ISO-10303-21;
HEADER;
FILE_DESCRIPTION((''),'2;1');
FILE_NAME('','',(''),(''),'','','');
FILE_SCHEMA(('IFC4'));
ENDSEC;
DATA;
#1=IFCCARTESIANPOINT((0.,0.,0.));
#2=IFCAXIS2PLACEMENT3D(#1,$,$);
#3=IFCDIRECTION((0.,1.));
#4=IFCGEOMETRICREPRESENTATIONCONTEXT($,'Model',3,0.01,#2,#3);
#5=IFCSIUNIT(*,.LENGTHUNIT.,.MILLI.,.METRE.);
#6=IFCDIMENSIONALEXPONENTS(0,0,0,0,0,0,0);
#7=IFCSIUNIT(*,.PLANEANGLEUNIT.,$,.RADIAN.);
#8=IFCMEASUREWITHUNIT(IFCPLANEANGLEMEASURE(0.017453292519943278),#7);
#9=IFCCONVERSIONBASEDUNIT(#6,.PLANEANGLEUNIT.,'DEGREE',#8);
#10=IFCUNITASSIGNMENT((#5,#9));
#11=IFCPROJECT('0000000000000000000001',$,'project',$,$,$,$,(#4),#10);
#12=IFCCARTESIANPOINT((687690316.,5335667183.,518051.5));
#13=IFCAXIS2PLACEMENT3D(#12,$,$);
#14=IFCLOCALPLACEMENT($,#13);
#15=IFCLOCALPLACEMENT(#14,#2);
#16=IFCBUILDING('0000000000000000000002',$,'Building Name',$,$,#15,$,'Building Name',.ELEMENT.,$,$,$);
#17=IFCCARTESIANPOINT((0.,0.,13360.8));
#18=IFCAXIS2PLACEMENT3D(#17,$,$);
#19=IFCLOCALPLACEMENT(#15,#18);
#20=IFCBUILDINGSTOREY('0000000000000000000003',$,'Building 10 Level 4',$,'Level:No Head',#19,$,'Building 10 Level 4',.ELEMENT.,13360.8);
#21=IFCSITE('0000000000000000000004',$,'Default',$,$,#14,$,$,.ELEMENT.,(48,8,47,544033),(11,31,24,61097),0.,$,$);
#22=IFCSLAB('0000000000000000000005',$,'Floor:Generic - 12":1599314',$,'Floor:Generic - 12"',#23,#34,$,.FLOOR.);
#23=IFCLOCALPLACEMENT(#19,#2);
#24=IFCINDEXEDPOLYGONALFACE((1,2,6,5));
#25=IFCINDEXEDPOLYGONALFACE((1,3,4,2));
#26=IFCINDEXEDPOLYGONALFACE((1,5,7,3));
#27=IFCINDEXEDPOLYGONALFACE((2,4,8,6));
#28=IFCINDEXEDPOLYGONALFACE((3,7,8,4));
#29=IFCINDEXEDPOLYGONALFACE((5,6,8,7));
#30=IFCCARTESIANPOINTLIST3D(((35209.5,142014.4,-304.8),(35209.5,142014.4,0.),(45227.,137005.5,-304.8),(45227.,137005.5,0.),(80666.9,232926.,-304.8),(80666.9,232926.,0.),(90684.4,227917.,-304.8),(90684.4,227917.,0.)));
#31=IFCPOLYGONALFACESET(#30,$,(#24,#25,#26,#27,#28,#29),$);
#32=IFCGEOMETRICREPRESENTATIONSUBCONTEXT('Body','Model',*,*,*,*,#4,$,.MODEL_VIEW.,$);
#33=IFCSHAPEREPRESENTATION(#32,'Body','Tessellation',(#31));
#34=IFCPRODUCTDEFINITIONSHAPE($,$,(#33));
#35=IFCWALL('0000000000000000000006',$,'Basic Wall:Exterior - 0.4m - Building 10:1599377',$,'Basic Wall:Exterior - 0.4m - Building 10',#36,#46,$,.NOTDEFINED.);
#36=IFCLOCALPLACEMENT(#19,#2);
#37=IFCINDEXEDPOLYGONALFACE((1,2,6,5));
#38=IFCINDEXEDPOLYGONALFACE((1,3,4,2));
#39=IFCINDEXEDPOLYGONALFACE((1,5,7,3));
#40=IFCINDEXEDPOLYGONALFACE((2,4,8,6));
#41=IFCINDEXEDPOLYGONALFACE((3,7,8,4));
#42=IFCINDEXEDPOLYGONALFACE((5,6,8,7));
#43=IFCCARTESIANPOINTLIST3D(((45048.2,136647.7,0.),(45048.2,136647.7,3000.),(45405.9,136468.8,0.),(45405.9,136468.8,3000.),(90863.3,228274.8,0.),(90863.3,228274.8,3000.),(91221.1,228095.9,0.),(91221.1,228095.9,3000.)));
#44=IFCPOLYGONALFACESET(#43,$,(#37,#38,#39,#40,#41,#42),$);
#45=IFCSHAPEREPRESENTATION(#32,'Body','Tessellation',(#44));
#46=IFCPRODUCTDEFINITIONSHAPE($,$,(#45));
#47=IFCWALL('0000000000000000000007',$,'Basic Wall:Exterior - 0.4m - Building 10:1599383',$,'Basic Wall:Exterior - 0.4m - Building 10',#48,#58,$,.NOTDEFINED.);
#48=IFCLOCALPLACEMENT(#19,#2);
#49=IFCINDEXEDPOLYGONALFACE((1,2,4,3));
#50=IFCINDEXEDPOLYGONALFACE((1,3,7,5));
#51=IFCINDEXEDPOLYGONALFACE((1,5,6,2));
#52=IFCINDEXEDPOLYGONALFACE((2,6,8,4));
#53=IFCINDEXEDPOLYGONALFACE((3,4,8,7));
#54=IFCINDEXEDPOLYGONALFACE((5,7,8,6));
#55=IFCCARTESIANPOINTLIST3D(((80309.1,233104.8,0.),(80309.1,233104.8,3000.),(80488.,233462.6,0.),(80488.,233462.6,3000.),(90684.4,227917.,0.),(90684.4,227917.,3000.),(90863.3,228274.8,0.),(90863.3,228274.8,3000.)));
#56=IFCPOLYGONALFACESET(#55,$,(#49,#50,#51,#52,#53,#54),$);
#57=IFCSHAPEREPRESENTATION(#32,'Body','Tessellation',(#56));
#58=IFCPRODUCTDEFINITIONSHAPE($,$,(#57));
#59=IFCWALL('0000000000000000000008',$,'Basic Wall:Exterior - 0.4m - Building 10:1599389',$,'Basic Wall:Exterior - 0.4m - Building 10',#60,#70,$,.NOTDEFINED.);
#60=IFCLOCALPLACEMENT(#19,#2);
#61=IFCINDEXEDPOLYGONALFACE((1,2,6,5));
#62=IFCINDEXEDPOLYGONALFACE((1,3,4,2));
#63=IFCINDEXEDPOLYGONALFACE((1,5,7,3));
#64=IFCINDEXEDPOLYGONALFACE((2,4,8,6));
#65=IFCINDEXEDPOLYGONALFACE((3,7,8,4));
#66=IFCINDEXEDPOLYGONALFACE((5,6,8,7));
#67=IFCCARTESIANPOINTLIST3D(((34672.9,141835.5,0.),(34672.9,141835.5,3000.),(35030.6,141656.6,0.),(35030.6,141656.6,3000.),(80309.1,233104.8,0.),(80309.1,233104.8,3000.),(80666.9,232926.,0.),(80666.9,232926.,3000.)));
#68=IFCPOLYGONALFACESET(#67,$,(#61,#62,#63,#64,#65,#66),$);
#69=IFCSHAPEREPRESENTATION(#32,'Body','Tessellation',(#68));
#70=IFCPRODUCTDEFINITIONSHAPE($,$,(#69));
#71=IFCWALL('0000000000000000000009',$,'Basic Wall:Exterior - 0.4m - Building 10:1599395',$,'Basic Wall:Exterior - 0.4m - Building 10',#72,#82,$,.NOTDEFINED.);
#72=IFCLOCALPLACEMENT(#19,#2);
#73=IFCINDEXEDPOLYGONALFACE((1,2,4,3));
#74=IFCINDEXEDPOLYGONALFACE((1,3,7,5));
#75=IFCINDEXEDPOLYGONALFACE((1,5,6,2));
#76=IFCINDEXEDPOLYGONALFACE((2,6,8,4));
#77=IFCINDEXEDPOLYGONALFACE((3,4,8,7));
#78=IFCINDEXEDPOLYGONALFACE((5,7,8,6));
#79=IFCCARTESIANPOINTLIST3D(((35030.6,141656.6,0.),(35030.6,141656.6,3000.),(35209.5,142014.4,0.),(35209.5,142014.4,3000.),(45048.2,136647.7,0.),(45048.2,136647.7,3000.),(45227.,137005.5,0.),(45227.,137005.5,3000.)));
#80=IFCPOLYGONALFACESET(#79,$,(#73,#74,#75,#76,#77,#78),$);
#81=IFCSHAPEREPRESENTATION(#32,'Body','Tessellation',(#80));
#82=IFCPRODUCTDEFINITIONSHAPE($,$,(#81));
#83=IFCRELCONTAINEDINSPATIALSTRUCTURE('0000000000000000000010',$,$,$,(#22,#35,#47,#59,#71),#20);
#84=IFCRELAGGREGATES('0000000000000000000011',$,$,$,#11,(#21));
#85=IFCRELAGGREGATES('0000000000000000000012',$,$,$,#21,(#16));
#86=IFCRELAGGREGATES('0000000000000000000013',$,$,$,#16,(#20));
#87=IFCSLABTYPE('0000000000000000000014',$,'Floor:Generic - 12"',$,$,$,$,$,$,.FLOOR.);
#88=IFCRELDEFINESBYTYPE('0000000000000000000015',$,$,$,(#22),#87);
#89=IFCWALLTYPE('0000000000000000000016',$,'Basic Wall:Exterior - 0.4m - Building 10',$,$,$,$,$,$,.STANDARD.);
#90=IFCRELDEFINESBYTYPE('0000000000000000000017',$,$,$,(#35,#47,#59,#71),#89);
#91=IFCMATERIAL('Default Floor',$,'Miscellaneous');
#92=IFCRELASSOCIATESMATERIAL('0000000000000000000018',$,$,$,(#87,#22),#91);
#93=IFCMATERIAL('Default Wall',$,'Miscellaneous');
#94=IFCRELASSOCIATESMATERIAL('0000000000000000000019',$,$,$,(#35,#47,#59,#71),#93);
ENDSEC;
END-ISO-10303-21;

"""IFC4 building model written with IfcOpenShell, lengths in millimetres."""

from ifc_helpers import new_model, entity, si_unit, converted_unit, direction, frame, origin, place, context, subcontext, project, spatial, indexed_curve, outline, extrude, material, type_object, element, save


model = new_model("IFC4")

# Units and contexts
model_context = context("Model", 3, precision=0.01, world=origin(), true_north=direction((0.0, 1.0)))
body_context = subcontext(model_context, "Body", "Model", "MODEL_VIEW")
ifc_project = project(units=[si_unit("LENGTHUNIT", "METRE", prefix="MILLI"), converted_unit("PLANEANGLEUNIT", "DEGREE", entity("IfcPlaneAngleMeasure", 0.017453292519943278), si_unit("PLANEANGLEUNIT", "RADIAN"), dimensions=[0, 0, 0, 0, 0, 0, 0])], contexts=[model_context])

# Site, building, storey
site_placement = place(None, frame((687690316.0, 5335667183.0, 518051.5)))
site = spatial("IfcSite", under=ifc_project, at=site_placement, Name="Default", CompositionType="ELEMENT", RefLatitude=(48, 8, 47, 544033), RefLongitude=(11, 31, 24, 61097), RefElevation=0.0)
building_placement = place(site_placement, origin())
building = spatial("IfcBuilding", under=site, at=building_placement, Name="Building Name", LongName="Building Name", CompositionType="ELEMENT")
storey_placement = place(building_placement, frame((0.0, 0.0, 13360.8)))
storey = spatial("IfcBuildingStorey", under=building, at=storey_placement, Name="Building 10 Level 4", ObjectType="Level:No Head", LongName="Building 10 Level 4", CompositionType="ELEMENT", Elevation=13360.8)

# Slab
ifc_material_1 = material(Name="Default Floor", Category="Miscellaneous")
slab_type = type_object("IfcSlabType", Name="Floor:Generic - 12\"", PredefinedType="FLOOR", material=ifc_material_1)
slab_placement = place(storey_placement, origin())
element("IfcSlab", 1, at=slab_placement, inside=storey, type_object=slab_type, material=ifc_material_1, Name="Floor:Generic - 12\":1599314", ObjectType="Floor:Generic - 12\"", PredefinedType="FLOOR", context=body_context, shape_type="SweptSolid", body=[
    extrude(outline(indexed_curve([(-50821.4, -5600.0), (50821.4, -5600.0), (50821.4, 5600.0), (-50821.4, 5600.0), (-50821.4, -5600.0)], self_intersect=False)), frame((62947.0, 184965.7, 0.0), z_axis=(0.0, 0.0, -1.0), x_axis=(-0.447226, -0.894421, 0.0)), (0.0, 0.0, 1.0), 304.8),
])

# Walls
ifc_material_2 = material(Name="Default Wall", Category="Miscellaneous")
wall_type = type_object("IfcWallType", Name="Basic Wall:Exterior - 0.4m - Building 10", PredefinedType="STANDARD")
wall_1_placement = place(storey_placement, frame((45227.0, 136558.3, 0.0), z_axis=(0.0, 0.0, 1.0), x_axis=(0.447226, 0.894421, 0.0)))
element("IfcWall", 2, at=wall_1_placement, inside=storey, type_object=wall_type, material=ifc_material_2, Name="Basic Wall:Exterior - 0.4m - Building 10:1599377", ObjectType="Basic Wall:Exterior - 0.4m - Building 10", PredefinedType="NOTDEFINED", context=body_context, shape_type="SweptSolid", body=[
    extrude(outline(indexed_curve([(102442.9, 200.0), (0.0, 200.0), (0.0, -200.0), (102442.9, -200.0), (102442.9, 200.0)], self_intersect=False)), origin(), (0.0, 0.0, 1.0), 3000.0),
])
wall_2_placement = place(storey_placement, frame((90773.8, 228095.9, 0.0), z_axis=(0.0, 0.0, 1.0), x_axis=(-0.894421, 0.447226, 0.0)))
element("IfcWall", 3, at=wall_2_placement, inside=storey, type_object=wall_type, material=ifc_material_2, Name="Basic Wall:Exterior - 0.4m - Building 10:1599383", ObjectType="Basic Wall:Exterior - 0.4m - Building 10", PredefinedType="NOTDEFINED", context=body_context, shape_type="SweptSolid", body=[
    extrude(outline(indexed_curve([(11600.0, 200.0), (0.0, 200.0), (0.0, -200.0), (11600.0, -200.0), (11600.0, 200.0)], self_intersect=False)), origin(), (0.0, 0.0, 1.0), 3000.0),
])
wall_3_placement = place(storey_placement, frame((80488.0, 233015.4, 0.0), z_axis=(0.0, 0.0, 1.0), x_axis=(-0.447226, -0.894421, 0.0)))
element("IfcWall", 4, at=wall_3_placement, inside=storey, type_object=wall_type, material=ifc_material_2, Name="Basic Wall:Exterior - 0.4m - Building 10:1599389", ObjectType="Basic Wall:Exterior - 0.4m - Building 10", PredefinedType="NOTDEFINED", context=body_context, shape_type="SweptSolid", body=[
    extrude(outline(indexed_curve([(102042.9, 200.0), (0.0, 200.0), (0.0, -200.0), (102042.9, -200.0), (102042.9, 200.0)], self_intersect=False)), origin(), (0.0, 0.0, 1.0), 3000.0),
])
wall_4_placement = place(storey_placement, frame((35120.1, 141835.5, 0.0), z_axis=(0.0, 0.0, 1.0), x_axis=(0.894421, -0.447226, 0.0)))
element("IfcWall", 5, at=wall_4_placement, inside=storey, type_object=wall_type, material=ifc_material_2, Name="Basic Wall:Exterior - 0.4m - Building 10:1599395", ObjectType="Basic Wall:Exterior - 0.4m - Building 10", PredefinedType="NOTDEFINED", context=body_context, shape_type="SweptSolid", body=[
    extrude(outline(indexed_curve([(11200.0, 200.0), (0.0, 200.0), (0.0, -200.0), (11200.0, -200.0), (11200.0, 200.0)], self_intersect=False)), origin(), (0.0, 0.0, 1.0), 3000.0),
])

save(model, "model.ifc")
